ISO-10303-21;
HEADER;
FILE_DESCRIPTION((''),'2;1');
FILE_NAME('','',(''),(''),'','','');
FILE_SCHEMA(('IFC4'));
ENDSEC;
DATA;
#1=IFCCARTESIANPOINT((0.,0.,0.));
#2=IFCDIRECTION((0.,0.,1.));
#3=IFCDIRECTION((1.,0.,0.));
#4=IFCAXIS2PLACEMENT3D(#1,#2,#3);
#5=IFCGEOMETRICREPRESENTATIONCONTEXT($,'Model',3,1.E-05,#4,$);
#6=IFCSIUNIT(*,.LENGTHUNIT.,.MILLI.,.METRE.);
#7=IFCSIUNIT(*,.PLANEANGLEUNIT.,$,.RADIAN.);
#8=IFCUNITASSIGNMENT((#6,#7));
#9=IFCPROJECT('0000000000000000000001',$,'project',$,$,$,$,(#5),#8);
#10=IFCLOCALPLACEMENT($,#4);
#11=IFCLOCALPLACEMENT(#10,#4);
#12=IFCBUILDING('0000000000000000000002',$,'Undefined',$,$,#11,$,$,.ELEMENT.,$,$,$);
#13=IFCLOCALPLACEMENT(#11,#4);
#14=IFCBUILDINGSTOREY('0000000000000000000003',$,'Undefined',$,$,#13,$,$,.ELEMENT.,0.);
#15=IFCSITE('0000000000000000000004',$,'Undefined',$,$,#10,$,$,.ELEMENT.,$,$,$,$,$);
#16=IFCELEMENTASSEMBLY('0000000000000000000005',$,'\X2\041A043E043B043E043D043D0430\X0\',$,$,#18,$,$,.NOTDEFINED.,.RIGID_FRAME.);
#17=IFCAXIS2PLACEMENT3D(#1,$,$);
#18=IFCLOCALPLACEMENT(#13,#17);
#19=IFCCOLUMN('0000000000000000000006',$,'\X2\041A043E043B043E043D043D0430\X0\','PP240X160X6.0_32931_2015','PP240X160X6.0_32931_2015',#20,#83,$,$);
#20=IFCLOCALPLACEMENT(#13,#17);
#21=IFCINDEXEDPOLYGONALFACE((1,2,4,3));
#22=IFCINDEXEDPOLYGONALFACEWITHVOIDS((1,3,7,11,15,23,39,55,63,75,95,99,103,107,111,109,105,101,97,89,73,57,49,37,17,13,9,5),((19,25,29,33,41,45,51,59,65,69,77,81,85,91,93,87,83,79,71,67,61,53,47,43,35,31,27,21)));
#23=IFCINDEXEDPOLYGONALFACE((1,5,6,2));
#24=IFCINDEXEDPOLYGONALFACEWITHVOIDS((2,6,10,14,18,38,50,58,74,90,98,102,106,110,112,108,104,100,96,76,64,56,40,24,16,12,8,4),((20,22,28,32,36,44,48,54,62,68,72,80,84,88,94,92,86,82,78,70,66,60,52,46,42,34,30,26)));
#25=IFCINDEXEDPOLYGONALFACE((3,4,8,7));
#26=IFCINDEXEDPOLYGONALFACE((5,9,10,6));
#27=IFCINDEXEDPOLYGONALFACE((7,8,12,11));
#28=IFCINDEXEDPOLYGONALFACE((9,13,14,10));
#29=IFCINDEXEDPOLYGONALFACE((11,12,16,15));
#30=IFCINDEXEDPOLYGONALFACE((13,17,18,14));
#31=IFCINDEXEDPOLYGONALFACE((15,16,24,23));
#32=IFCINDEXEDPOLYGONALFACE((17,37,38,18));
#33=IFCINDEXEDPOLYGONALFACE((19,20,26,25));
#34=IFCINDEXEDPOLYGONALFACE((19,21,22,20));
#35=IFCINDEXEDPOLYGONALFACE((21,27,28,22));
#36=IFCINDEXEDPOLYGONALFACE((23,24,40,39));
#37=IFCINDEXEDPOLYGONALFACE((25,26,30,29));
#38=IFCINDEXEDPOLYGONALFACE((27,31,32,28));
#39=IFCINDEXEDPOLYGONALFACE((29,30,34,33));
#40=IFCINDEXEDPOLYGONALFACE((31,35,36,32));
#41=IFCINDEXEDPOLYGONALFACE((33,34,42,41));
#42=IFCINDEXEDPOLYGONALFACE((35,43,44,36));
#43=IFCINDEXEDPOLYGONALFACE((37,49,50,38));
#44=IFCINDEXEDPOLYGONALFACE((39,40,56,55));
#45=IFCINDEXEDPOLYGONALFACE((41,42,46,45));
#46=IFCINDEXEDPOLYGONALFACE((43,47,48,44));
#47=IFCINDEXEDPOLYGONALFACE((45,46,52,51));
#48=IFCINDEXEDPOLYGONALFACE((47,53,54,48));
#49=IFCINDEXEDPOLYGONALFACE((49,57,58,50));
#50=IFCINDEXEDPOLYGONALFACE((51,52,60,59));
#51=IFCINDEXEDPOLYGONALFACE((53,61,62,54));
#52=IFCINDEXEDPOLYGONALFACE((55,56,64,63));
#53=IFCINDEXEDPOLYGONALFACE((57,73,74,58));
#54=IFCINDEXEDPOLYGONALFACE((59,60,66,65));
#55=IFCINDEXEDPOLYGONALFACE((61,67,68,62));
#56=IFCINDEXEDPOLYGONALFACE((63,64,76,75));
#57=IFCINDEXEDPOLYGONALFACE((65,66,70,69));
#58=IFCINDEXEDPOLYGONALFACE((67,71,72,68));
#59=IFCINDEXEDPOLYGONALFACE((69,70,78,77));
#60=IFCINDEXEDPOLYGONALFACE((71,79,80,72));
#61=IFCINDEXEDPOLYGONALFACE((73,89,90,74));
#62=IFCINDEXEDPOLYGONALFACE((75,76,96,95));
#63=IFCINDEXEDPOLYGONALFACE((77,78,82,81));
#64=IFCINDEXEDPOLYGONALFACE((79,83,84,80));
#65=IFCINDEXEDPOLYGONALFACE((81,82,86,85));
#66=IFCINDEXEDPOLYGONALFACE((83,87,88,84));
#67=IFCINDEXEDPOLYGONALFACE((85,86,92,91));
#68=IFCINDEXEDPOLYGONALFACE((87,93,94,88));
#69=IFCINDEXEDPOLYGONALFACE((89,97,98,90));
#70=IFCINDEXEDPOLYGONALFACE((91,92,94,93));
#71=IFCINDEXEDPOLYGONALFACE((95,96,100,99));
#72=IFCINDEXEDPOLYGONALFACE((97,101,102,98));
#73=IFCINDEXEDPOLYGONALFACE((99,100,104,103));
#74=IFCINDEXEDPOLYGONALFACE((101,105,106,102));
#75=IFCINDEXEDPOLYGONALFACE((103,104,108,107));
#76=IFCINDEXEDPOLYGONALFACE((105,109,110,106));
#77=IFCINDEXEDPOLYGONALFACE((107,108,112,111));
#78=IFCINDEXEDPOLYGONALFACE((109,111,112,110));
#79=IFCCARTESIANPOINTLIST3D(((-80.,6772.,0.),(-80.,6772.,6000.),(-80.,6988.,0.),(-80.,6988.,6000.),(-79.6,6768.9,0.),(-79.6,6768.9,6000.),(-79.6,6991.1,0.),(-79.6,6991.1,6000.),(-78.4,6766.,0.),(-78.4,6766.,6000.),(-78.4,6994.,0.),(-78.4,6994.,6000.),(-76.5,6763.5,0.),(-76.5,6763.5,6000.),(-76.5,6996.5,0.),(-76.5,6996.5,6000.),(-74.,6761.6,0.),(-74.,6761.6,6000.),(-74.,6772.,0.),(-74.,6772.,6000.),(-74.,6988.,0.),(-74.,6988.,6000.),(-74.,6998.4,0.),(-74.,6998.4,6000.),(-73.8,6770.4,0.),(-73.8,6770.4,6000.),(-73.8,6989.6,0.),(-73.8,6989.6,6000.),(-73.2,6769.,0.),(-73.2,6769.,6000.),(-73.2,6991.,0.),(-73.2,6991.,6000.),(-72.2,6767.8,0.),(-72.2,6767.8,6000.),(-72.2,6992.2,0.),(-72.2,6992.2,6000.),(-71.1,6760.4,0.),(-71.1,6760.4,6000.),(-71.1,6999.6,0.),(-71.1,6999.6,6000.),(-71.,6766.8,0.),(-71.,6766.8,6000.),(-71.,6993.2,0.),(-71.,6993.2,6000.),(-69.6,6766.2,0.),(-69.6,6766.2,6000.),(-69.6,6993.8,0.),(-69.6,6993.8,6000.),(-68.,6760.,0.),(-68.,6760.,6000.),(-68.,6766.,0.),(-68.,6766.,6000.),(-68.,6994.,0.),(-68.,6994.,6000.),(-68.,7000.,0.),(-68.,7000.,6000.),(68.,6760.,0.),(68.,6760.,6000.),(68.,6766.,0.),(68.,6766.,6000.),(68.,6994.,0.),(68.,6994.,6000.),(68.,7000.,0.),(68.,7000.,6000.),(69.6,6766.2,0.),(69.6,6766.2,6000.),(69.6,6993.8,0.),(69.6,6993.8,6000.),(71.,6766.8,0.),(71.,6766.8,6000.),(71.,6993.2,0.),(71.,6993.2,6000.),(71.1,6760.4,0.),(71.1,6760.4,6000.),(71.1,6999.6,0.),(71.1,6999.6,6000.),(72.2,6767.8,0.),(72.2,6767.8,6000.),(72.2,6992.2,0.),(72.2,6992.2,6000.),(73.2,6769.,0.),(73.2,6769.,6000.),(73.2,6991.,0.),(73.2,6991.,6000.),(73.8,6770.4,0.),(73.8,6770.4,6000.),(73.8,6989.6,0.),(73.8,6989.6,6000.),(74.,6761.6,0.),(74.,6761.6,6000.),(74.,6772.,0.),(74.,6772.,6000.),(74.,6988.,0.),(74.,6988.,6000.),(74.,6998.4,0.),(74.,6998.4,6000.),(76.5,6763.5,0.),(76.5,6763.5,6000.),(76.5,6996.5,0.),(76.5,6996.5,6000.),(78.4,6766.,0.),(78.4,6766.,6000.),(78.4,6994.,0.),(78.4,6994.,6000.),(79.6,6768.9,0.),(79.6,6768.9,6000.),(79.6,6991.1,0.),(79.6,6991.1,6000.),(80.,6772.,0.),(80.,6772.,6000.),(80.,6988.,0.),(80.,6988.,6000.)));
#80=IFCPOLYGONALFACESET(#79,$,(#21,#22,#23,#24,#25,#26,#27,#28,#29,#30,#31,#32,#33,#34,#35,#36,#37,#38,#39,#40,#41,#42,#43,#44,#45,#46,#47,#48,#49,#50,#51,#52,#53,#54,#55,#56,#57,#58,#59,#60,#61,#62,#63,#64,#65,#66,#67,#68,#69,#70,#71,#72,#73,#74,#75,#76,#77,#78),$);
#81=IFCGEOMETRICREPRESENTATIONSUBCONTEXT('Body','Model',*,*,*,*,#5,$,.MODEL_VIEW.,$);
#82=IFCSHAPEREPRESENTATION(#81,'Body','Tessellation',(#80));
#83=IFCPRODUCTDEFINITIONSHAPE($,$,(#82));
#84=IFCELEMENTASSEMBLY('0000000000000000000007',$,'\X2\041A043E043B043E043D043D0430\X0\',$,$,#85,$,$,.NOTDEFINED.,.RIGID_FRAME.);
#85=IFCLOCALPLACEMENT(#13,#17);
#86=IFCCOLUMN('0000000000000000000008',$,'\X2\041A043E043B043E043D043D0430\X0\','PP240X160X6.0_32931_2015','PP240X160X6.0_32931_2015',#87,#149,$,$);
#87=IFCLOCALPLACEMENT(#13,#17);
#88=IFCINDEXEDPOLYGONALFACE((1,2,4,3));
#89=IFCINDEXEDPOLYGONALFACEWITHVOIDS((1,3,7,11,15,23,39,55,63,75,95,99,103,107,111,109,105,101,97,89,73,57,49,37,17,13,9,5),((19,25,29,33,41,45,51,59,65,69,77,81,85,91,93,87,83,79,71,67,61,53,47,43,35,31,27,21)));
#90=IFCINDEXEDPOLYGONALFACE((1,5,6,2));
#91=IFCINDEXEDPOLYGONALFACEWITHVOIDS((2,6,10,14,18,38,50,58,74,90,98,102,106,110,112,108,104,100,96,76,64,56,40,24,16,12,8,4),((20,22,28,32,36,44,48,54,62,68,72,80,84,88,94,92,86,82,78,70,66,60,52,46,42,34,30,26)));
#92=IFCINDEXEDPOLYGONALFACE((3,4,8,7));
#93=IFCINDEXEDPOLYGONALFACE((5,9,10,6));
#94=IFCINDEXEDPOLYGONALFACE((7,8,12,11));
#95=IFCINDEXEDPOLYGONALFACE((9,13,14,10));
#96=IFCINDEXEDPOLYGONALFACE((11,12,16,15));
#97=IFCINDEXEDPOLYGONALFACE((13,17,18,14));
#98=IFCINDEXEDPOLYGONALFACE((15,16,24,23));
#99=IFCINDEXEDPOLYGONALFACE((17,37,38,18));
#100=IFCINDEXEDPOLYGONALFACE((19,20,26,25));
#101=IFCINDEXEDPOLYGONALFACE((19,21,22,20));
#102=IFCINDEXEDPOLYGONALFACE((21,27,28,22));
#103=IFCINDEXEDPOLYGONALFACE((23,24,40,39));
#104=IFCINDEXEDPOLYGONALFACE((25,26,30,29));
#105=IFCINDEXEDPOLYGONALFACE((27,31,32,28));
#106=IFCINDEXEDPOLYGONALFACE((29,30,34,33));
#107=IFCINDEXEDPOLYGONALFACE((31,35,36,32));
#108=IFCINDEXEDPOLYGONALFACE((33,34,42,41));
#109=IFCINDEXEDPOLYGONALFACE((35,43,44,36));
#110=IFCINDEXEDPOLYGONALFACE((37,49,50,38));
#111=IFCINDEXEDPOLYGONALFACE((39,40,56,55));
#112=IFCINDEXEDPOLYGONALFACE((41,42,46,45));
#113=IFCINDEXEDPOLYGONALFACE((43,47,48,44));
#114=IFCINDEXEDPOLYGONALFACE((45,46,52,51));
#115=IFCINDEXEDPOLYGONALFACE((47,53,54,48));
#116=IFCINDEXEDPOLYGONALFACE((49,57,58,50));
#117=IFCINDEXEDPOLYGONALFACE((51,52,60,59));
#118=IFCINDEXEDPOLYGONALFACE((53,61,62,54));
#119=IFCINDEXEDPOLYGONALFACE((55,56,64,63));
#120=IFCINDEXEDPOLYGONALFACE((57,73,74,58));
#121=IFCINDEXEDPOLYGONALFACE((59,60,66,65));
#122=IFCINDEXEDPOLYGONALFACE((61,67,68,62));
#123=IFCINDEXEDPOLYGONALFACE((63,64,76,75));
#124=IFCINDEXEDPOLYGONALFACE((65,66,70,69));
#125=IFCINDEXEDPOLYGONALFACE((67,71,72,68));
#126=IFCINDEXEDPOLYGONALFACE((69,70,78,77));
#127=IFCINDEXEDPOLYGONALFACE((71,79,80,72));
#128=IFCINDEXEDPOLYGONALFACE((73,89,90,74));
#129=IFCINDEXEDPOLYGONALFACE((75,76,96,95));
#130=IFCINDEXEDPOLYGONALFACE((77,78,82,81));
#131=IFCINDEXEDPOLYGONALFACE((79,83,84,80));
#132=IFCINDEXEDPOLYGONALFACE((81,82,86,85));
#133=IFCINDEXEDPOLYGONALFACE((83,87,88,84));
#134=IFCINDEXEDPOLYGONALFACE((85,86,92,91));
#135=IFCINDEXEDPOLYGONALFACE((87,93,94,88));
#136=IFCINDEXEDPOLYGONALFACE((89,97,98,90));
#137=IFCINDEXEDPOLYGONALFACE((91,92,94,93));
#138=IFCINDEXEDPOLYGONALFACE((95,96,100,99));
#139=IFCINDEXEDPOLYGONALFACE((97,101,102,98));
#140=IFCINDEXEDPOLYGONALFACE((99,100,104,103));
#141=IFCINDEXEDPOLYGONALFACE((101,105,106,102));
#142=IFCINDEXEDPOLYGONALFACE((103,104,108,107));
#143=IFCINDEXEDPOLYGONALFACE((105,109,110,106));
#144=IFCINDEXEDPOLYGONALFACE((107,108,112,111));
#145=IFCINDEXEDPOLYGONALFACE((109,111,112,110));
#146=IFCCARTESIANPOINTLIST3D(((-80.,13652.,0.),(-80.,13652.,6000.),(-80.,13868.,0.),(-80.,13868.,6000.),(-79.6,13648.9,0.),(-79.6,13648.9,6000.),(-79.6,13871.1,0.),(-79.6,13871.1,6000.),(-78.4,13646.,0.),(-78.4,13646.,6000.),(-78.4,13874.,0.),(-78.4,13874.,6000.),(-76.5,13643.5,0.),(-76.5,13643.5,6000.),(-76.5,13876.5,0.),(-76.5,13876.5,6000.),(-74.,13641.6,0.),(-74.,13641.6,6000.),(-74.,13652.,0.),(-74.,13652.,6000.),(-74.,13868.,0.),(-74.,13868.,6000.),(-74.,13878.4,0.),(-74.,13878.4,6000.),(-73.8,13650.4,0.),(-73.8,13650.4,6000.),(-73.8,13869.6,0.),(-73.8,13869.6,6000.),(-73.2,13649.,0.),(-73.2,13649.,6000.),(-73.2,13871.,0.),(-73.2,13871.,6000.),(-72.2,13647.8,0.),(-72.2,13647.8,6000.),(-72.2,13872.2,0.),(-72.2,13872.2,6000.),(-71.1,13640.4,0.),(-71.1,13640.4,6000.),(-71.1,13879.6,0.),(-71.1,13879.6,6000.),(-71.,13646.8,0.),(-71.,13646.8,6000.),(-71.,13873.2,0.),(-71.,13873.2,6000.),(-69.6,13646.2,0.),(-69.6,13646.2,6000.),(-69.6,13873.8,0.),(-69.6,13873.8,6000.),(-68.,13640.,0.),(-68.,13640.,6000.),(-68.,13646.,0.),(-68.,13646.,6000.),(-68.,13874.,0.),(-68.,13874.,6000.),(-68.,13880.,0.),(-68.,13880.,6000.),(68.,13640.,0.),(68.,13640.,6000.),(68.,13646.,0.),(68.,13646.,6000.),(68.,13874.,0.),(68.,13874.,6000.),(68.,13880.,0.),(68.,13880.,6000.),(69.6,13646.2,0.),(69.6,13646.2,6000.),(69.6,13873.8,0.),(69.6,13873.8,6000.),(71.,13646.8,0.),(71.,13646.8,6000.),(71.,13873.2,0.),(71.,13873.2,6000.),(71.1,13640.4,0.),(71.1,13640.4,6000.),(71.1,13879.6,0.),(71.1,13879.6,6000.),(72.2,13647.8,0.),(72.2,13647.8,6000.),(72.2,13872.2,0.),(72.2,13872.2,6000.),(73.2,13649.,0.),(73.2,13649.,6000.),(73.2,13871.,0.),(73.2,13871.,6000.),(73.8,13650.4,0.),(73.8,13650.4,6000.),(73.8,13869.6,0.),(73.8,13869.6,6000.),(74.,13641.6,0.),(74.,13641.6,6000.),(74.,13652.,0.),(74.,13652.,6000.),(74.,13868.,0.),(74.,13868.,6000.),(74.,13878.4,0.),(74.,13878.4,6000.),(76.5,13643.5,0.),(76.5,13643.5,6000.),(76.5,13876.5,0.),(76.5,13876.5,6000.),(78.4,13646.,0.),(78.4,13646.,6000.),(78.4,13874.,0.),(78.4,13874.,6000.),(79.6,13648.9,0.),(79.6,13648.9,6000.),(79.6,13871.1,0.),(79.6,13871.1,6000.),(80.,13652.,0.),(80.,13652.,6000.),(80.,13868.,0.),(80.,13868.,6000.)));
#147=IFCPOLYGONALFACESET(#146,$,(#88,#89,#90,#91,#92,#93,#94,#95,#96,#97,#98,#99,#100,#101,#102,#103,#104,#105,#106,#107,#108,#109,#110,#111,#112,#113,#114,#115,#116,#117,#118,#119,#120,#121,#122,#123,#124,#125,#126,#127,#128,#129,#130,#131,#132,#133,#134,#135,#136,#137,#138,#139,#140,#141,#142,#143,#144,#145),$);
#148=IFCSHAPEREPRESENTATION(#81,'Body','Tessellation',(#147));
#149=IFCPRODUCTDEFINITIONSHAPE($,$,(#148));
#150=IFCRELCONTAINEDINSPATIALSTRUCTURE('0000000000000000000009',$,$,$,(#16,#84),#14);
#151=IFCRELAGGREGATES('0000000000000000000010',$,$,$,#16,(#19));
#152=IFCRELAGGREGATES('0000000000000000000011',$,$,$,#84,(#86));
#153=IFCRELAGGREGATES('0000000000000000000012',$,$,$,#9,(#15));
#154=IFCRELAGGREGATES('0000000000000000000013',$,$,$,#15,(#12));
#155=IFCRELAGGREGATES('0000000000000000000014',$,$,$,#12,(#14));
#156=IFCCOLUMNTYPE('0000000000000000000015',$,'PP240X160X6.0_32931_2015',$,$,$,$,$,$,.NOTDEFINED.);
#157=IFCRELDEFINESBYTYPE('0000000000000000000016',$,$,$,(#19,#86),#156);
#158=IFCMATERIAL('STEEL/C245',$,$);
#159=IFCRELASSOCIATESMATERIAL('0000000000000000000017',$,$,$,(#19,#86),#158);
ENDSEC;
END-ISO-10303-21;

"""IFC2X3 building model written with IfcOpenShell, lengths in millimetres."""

from ifc_helpers import new_model, si_unit, frame, origin_with_axes, origin_2d_with_axis, place, context, subcontext, project, spatial, hollow_rectangle, extrude, material, type_object, element, aggregate, save


model = new_model("IFC2X3")

# Units and contexts
model_context = context("Model", 3, precision=1e-05, world=origin_with_axes())
body_context = subcontext(model_context, "Body", "Model", "MODEL_VIEW")
ifc_project = project(units=[si_unit("LENGTHUNIT", "METRE", prefix="MILLI"), si_unit("PLANEANGLEUNIT", "RADIAN")], contexts=[model_context])

# Site, building, storey
site_placement = place(None, origin_with_axes())
site = spatial("IfcSite", under=ifc_project, at=site_placement, Name="Undefined", CompositionType="ELEMENT")
building_placement = place(site_placement, origin_with_axes())
building = spatial("IfcBuilding", under=site, at=building_placement, Name="Undefined", CompositionType="ELEMENT")
storey_placement = place(building_placement, origin_with_axes())
storey = spatial("IfcBuildingStorey", under=building, at=storey_placement, Name="Undefined", CompositionType="ELEMENT", Elevation=0.0)

# Element assemblies, columns
assembly_1_placement = place(storey_placement, origin_with_axes())
assembly_1 = element("IfcElementAssembly", 1, at=assembly_1_placement, inside=storey, Name="Колонна", AssemblyPlace="NOTDEFINED", PredefinedType="RIGID_FRAME")
ifc_material = material(Name="STEEL/C245")
column_type_1 = type_object("IfcColumnType", Name="PP240X160X6.0_32931_2015", PredefinedType="NOTDEFINED")
column_1_placement = place(assembly_1_placement, frame((0.0, 6880.0, 0.0), z_axis=(0.0, 0.0, 1.0), x_axis=(0.0, 1.0, 0.0)))
column_1 = element("IfcColumn", 2, at=column_1_placement, type_object=column_type_1, material=ifc_material, Name="Колонна", Description="PP240X160X6.0_32931_2015", ObjectType="PP240X160X6.0_32931_2015", context=body_context, shape_type="SweptSolid", body=[
    extrude(hollow_rectangle(XDim=160.0, YDim=240.0, WallThickness=6.0, InnerFilletRadius=6.0, OuterFilletRadius=12.0, at=origin_2d_with_axis()), frame((0.0, 0.0, 6000.0), z_axis=(0.0, 0.0, -1.0), x_axis=(0.0, 1.0, 0.0)), (0.0, 0.0, 1.0), 6000.0),
])
aggregate(assembly_1, [column_1])
assembly_2_placement = place(storey_placement, origin_with_axes())
assembly_2 = element("IfcElementAssembly", 3, at=assembly_2_placement, inside=storey, Name="Колонна", AssemblyPlace="NOTDEFINED", PredefinedType="RIGID_FRAME")
column_2_placement = place(assembly_2_placement, frame((0.0, 13760.0, 0.0), z_axis=(0.0, 0.0, 1.0), x_axis=(0.0, 1.0, 0.0)))
column_2 = element("IfcColumn", 4, at=column_2_placement, type_object=column_type_1, material=ifc_material, Name="Колонна", Description="PP240X160X6.0_32931_2015", ObjectType="PP240X160X6.0_32931_2015", context=body_context, shape_type="SweptSolid", body=[
    extrude(hollow_rectangle(XDim=160.0, YDim=240.0, WallThickness=6.0, InnerFilletRadius=6.0, OuterFilletRadius=12.0, at=origin_2d_with_axis()), frame((0.0, 0.0, 6000.0), z_axis=(0.0, 0.0, -1.0), x_axis=(0.0, 1.0, 0.0)), (0.0, 0.0, 1.0), 6000.0),
])
aggregate(assembly_2, [column_2])

save(model, "model.ifc")
